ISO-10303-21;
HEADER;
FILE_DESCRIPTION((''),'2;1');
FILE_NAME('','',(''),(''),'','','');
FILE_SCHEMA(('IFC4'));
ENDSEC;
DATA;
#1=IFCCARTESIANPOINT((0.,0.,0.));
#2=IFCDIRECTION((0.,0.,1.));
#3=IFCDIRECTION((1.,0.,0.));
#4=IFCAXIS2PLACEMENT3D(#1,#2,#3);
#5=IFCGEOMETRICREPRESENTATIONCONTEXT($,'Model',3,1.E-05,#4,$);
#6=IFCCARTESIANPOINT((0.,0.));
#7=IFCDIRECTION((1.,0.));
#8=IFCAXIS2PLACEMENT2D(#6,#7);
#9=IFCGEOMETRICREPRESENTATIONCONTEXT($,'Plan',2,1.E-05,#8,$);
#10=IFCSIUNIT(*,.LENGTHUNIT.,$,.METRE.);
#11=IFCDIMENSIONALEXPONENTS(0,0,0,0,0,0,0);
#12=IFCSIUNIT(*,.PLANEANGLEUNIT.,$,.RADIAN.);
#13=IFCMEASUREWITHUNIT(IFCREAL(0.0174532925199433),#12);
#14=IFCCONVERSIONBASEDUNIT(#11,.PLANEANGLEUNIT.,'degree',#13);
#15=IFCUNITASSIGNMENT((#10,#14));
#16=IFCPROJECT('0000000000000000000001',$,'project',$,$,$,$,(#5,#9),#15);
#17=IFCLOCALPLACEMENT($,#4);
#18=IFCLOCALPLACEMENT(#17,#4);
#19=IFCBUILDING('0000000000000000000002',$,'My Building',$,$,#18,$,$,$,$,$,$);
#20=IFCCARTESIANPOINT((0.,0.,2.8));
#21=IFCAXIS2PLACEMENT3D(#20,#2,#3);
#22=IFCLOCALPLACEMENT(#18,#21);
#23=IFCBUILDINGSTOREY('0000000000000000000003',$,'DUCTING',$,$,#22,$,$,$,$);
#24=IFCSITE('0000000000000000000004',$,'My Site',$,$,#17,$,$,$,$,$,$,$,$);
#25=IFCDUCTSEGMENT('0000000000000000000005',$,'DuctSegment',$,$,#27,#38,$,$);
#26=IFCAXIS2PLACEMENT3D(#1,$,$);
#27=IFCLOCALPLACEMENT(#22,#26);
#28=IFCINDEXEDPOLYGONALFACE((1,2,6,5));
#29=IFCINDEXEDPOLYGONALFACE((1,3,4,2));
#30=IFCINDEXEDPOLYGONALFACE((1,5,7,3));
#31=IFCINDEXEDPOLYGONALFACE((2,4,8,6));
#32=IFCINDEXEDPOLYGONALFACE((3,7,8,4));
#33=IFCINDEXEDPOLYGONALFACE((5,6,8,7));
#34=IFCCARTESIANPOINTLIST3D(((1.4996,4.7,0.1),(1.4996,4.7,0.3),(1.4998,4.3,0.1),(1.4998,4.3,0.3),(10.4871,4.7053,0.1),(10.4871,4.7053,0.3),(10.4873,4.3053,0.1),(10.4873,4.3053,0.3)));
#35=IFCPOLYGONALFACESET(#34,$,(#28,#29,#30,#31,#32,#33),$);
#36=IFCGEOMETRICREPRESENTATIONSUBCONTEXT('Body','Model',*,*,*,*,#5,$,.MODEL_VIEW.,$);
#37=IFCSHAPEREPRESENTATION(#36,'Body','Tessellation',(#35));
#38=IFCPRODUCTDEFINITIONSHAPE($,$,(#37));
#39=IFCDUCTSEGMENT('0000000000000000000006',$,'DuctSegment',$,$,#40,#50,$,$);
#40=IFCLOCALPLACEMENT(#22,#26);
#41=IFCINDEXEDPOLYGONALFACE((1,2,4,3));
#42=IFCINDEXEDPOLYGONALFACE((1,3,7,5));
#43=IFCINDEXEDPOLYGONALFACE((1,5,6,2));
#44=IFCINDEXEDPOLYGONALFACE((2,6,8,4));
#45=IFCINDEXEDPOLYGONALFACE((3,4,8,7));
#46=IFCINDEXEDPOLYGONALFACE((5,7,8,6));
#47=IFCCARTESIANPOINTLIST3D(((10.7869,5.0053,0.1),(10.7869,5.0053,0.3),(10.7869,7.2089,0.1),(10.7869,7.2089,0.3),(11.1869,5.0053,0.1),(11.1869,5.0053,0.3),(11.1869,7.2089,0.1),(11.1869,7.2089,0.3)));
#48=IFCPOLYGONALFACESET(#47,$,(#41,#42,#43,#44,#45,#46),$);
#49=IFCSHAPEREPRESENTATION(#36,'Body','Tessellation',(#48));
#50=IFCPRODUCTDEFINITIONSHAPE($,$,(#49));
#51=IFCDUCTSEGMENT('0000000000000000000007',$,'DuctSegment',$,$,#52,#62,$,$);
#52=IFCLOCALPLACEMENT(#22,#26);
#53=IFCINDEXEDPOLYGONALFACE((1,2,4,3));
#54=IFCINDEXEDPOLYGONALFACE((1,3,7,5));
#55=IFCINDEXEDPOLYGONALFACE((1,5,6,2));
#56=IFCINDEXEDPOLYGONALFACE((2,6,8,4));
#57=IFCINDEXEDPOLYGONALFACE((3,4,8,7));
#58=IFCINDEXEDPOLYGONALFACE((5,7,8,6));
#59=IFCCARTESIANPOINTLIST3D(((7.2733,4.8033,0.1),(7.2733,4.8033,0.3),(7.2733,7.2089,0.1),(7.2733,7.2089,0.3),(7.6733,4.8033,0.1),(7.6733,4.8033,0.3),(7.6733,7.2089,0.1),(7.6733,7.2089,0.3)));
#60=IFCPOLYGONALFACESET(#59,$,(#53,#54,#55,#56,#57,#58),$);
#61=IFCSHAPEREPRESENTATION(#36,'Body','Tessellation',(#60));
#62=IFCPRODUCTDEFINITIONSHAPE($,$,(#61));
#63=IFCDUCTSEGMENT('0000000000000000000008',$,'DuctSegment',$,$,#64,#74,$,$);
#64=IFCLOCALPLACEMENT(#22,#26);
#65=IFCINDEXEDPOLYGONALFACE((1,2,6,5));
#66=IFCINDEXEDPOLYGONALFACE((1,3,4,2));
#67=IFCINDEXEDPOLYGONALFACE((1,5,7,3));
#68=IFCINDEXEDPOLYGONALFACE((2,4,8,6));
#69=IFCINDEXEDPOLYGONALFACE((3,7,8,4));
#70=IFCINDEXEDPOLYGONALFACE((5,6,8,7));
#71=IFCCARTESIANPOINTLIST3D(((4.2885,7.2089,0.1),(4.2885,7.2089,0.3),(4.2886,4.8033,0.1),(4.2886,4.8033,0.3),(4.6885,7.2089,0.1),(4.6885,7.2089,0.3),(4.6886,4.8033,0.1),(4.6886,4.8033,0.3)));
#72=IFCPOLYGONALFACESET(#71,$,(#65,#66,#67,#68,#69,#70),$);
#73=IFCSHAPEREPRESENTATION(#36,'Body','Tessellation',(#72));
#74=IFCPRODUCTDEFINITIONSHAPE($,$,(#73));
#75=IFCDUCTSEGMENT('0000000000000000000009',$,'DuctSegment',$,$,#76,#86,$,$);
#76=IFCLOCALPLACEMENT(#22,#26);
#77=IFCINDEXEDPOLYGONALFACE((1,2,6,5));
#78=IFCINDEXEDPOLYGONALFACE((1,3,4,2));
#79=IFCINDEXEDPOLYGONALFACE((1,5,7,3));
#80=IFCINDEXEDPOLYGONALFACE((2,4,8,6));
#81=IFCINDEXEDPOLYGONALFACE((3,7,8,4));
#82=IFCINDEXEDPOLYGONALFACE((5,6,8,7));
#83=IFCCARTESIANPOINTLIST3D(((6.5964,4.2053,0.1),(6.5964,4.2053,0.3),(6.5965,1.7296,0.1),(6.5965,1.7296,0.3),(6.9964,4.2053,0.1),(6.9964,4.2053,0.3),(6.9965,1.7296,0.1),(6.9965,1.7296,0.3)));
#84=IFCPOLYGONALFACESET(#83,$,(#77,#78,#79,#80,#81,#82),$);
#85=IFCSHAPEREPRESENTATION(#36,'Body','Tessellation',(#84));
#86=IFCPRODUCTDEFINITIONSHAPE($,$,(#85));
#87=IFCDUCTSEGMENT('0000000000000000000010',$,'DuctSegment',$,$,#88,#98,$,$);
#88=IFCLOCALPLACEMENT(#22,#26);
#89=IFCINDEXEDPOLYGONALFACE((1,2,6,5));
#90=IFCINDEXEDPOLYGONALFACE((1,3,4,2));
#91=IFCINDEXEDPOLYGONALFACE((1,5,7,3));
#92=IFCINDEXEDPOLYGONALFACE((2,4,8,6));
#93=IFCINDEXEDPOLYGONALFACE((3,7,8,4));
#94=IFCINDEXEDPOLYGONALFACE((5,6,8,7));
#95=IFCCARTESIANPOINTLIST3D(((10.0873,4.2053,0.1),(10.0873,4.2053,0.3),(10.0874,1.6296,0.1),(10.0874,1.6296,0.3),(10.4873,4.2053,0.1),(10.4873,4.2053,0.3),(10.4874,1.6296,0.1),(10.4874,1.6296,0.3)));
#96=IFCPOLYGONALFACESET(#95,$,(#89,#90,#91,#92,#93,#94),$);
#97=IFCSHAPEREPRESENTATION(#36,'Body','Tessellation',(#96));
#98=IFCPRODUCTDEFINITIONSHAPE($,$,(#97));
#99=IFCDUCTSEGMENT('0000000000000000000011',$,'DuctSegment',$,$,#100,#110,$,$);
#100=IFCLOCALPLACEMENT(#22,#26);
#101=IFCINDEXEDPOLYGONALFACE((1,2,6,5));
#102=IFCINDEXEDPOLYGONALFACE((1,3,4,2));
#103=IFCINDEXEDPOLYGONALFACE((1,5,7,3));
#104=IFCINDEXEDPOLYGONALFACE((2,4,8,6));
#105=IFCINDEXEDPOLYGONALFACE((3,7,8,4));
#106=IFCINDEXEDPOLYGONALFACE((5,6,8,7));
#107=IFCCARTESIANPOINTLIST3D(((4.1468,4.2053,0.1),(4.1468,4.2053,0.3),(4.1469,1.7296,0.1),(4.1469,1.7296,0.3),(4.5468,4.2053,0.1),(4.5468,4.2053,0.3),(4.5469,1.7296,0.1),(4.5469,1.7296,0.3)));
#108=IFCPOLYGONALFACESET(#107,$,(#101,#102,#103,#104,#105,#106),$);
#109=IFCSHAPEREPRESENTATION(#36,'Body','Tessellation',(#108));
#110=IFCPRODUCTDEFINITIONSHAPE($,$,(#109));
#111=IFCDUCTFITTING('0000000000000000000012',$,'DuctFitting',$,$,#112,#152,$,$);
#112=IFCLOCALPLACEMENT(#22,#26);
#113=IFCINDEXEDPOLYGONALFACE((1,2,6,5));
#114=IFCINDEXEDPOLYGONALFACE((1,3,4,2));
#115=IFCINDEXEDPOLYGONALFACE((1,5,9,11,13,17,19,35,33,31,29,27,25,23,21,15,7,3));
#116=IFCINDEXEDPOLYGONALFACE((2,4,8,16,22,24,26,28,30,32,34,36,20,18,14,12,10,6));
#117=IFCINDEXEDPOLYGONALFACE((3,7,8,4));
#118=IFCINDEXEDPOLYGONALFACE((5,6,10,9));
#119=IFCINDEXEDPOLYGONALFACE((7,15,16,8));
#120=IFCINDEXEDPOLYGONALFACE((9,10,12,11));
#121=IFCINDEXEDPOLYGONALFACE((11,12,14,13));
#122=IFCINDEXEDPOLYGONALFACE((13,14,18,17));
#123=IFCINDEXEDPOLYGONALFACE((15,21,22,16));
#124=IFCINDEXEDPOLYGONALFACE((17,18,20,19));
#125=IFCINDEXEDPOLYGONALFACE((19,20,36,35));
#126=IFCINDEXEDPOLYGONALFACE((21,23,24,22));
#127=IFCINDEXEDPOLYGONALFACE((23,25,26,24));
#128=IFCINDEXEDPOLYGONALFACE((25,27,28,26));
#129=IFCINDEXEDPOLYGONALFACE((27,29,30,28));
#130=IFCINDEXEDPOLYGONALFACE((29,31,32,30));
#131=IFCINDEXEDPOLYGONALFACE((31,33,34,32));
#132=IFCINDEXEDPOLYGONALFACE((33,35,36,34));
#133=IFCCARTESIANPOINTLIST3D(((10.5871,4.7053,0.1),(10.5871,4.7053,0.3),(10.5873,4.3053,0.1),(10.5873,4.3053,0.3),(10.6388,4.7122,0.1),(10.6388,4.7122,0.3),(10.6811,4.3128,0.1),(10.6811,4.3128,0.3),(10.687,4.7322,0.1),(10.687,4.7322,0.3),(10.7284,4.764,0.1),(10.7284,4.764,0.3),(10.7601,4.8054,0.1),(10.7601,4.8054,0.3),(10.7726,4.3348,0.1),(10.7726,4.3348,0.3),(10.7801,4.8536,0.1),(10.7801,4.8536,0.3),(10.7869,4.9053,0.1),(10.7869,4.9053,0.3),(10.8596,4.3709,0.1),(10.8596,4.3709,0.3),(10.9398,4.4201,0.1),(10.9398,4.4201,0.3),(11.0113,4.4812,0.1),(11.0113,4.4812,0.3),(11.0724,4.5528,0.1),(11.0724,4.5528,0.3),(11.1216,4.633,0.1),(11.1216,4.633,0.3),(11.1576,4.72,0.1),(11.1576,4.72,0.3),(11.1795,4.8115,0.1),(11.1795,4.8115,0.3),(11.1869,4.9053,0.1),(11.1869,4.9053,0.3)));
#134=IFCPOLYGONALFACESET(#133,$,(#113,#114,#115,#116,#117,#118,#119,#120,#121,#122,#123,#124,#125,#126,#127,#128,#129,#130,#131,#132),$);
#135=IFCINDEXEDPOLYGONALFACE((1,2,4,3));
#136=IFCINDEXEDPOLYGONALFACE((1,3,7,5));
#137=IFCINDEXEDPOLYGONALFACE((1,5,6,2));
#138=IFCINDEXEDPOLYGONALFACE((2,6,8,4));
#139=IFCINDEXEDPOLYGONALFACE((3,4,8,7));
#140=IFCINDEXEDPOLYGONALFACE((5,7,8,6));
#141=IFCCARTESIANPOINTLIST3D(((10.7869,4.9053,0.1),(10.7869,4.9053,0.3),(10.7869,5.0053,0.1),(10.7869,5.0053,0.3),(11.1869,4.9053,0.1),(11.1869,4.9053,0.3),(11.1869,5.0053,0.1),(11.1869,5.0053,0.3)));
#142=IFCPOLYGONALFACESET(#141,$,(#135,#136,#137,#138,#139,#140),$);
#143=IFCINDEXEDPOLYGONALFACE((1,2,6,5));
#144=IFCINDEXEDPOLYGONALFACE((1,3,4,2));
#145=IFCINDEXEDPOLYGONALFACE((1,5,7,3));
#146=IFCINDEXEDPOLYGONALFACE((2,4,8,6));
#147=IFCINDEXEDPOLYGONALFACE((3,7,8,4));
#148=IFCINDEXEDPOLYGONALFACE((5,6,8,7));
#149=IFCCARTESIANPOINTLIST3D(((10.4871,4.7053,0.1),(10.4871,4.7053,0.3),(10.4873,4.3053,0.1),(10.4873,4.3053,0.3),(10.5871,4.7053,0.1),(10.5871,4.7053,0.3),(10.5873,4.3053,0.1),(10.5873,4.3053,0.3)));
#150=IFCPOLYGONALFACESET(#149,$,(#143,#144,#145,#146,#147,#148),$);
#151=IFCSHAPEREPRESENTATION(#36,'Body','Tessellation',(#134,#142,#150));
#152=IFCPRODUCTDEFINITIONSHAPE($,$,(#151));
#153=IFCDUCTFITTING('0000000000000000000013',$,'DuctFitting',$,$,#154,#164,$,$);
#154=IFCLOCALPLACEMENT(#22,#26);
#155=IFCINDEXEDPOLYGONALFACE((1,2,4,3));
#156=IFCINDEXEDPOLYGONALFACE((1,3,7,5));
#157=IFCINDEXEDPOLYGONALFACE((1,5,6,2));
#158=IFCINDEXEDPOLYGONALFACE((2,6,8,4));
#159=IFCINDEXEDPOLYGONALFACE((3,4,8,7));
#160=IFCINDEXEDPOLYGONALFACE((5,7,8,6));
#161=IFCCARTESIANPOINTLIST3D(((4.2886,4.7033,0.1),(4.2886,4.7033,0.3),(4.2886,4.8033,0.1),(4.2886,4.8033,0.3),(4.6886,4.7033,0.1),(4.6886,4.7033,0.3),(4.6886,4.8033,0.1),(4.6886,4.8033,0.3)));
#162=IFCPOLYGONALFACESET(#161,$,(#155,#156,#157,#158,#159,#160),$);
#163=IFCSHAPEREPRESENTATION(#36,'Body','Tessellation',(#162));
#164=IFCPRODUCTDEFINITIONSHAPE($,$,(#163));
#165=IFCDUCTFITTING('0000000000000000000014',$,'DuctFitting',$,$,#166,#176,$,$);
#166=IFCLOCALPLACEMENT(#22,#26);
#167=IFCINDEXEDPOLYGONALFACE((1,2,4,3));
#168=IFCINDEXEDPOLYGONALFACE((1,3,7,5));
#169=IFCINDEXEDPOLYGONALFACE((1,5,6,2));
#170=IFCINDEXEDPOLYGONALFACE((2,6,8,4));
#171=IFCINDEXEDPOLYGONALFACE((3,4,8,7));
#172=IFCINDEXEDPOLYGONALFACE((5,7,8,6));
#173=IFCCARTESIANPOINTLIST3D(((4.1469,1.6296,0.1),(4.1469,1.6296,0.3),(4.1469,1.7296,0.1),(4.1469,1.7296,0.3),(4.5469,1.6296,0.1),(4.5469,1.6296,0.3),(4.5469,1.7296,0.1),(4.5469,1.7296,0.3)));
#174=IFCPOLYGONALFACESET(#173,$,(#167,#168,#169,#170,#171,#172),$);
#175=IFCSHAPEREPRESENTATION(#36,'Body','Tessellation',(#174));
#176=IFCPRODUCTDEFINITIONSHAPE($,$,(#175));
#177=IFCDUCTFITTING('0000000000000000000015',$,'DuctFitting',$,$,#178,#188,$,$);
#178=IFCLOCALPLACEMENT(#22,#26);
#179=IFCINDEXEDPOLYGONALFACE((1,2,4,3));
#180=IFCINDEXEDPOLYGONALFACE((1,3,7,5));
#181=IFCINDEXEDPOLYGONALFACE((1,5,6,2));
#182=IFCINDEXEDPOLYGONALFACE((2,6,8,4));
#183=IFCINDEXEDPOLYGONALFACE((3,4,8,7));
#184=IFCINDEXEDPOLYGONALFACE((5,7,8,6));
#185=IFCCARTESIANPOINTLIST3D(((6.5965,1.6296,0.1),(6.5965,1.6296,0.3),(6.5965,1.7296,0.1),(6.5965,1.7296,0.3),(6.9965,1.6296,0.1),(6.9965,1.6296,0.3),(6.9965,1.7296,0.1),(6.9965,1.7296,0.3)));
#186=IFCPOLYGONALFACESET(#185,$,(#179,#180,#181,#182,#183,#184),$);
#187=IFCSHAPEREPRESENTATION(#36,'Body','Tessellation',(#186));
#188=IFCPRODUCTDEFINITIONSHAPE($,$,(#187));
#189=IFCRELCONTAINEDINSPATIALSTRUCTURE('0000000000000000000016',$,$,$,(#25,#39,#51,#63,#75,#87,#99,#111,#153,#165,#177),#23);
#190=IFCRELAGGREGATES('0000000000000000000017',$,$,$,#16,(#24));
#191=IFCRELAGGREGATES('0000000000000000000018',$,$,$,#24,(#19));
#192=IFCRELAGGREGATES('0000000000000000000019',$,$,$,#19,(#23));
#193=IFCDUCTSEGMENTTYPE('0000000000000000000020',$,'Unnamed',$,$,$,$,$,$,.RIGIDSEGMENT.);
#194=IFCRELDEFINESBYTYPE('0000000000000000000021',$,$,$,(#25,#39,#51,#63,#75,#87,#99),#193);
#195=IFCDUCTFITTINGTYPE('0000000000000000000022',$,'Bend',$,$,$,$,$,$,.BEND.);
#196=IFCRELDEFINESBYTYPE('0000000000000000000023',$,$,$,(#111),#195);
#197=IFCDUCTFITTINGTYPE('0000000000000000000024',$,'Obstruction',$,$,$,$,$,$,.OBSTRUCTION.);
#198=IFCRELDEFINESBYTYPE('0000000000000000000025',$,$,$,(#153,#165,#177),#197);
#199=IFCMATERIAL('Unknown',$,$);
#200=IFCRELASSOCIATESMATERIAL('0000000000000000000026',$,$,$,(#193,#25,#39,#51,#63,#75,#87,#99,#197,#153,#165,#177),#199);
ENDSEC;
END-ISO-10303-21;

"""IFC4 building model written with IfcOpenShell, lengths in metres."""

from ifc_helpers import new_model, entity, si_unit, converted_unit, frame, origin_with_axes, origin_2d_with_axis, place, context, subcontext, project, spatial, line, arc, indexed_curve, rectangle, outline, extrude, source, transform, mapped, material, material_profile, profile_set, profile_usage, type_object, type_shapes, element, save


model = new_model("IFC4")

# Units and contexts
model_context = context("Model", 3, precision=1e-05, world=origin_with_axes())
plan_context = context("Plan", 2, precision=1e-05, world=origin_2d_with_axis())
body_context = subcontext(model_context, "Body", "Model", "MODEL_VIEW")
ifc_project = project(units=[si_unit("LENGTHUNIT", "METRE"), converted_unit("PLANEANGLEUNIT", "degree", entity("IfcReal", 0.0174532925199433), si_unit("PLANEANGLEUNIT", "RADIAN"), dimensions=[0, 0, 0, 0, 0, 0, 0])], contexts=[model_context, plan_context])

# Site, building, storey
site_placement = place(None, origin_with_axes())
site = spatial("IfcSite", under=ifc_project, at=site_placement, Name="My Site")
building_placement = place(site_placement, origin_with_axes())
building = spatial("IfcBuilding", under=site, at=building_placement, Name="My Building")
storey_placement = place(building_placement, frame((0.0, 0.0, 2.8), z_axis=(0.0, 0.0, 1.0), x_axis=(1.0, 0.0, 0.0)))
storey = spatial("IfcBuildingStorey", under=building, at=storey_placement, Name="DUCTING")

# Duct segments
ifc_material = material(Name="Unknown")
ifc_material_profile_1 = material_profile(ifc_material, rectangle(XDim=0.4, YDim=0.2))
ifc_profile_set_1 = profile_set([ifc_material_profile_1])
ifc_profile_usage_1 = profile_usage(ifc_profile_set_1, cardinal=5)
duct_segment_type = type_object("IfcDuctSegmentType", Name="Unnamed", PredefinedType="RIGIDSEGMENT", material=ifc_profile_set_1)
duct_segment_1_placement = place(storey_placement, frame((1.4997, 4.5, 0.2), z_axis=(1.0, 0.000585, 0.0), x_axis=(-0.000585, 1.0, 0.0)))
element("IfcDuctSegment", 1, at=duct_segment_1_placement, inside=storey, type_object=duct_segment_type, material=ifc_profile_usage_1, Name="DuctSegment", context=body_context, shape_type="SweptSolid", body=[
    extrude(rectangle(XDim=0.4, YDim=0.2), origin_with_axes(), (0.0, 0.0, 1.0), 8.9875),
])
ifc_profile_usage_2 = profile_usage(ifc_profile_set_1, cardinal=5)
duct_segment_2_placement = place(storey_placement, frame((10.9869, 5.0053, 0.2), z_axis=(0.0, 1.0, 0.0), x_axis=(-1.0, 0.0, 0.0)))
element("IfcDuctSegment", 2, at=duct_segment_2_placement, inside=storey, type_object=duct_segment_type, material=ifc_profile_usage_2, Name="DuctSegment", context=body_context, shape_type="SweptSolid", body=[
    extrude(rectangle(XDim=0.4, YDim=0.2), origin_with_axes(), (0.0, 0.0, 1.0), 2.2036),
])
ifc_profile_usage_3 = profile_usage(ifc_profile_set_1, cardinal=5)
duct_segment_3_placement = place(storey_placement, frame((7.4733, 4.8033, 0.2), z_axis=(-0.000031, 1.0, 0.0), x_axis=(-1.0, -0.000031, 0.0)))
element("IfcDuctSegment", 3, at=duct_segment_3_placement, inside=storey, type_object=duct_segment_type, material=ifc_profile_usage_3, Name="DuctSegment", context=body_context, shape_type="SweptSolid", body=[
    extrude(rectangle(XDim=0.4, YDim=0.2), origin_with_axes(), (0.0, 0.0, 1.0), 2.4056),
])
ifc_profile_usage_4 = profile_usage(ifc_profile_set_1, cardinal=5)
duct_segment_4_placement = place(storey_placement, frame((4.4886, 4.8033, 0.2), z_axis=(-0.000031, 1.0, 0.0), x_axis=(-1.0, -0.000031, 0.0)))
element("IfcDuctSegment", 4, at=duct_segment_4_placement, inside=storey, type_object=duct_segment_type, material=ifc_profile_usage_4, Name="DuctSegment", context=body_context, shape_type="SweptSolid", body=[
    extrude(rectangle(XDim=0.4, YDim=0.2), origin_with_axes(), (0.0, 0.0, 1.0), 2.4056),
])
ifc_profile_usage_5 = profile_usage(ifc_profile_set_1, cardinal=5)
duct_segment_5_placement = place(storey_placement, frame((6.7965, 1.7296, 0.2), z_axis=(-0.000031, 1.0, 0.0), x_axis=(-1.0, -0.000031, 0.0)))
element("IfcDuctSegment", 5, at=duct_segment_5_placement, inside=storey, type_object=duct_segment_type, material=ifc_profile_usage_5, Name="DuctSegment", context=body_context, shape_type="SweptSolid", body=[
    extrude(rectangle(XDim=0.4, YDim=0.2), origin_with_axes(), (0.0, 0.0, 1.0), 2.4756),
])
ifc_profile_usage_6 = profile_usage(ifc_profile_set_1, cardinal=5)
duct_segment_6_placement = place(storey_placement, frame((10.2874, 1.6296, 0.2), z_axis=(-0.000031, 1.0, 0.0), x_axis=(-1.0, -0.000031, 0.0)))
element("IfcDuctSegment", 6, at=duct_segment_6_placement, inside=storey, type_object=duct_segment_type, material=ifc_profile_usage_6, Name="DuctSegment", context=body_context, shape_type="SweptSolid", body=[
    extrude(rectangle(XDim=0.4, YDim=0.2), origin_with_axes(), (0.0, 0.0, 1.0), 2.5756),
])
ifc_profile_usage_7 = profile_usage(ifc_profile_set_1, cardinal=5)
duct_segment_7_placement = place(storey_placement, frame((4.3469, 1.7296, 0.2), z_axis=(-0.000031, 1.0, 0.0), x_axis=(-1.0, -0.000031, 0.0)))
element("IfcDuctSegment", 7, at=duct_segment_7_placement, inside=storey, type_object=duct_segment_type, material=ifc_profile_usage_7, Name="DuctSegment", context=body_context, shape_type="SweptSolid", body=[
    extrude(rectangle(XDim=0.4, YDim=0.2), origin_with_axes(), (0.0, 0.0, 1.0), 2.4756),
])

# Duct fittings
duct_fitting_type_1 = type_object("IfcDuctFittingType", Name="Bend", PredefinedType="BEND")
shared_shape = source(origin_with_axes(), body_context, "Body", "SweptSolid", [
    extrude(outline(indexed_curve([(0.2, 0.0), (0.2585, -0.1414), (0.3999, -0.2), (0.3996, -0.6), (-0.0244, -0.4241), (-0.2, 0.0)], segments=[arc(1, 2, 3), line(3, 4), arc(4, 5, 6), line(6, 1)])), frame((0.0, -0.1, -0.1), z_axis=(0.0, -1.0, 0.0), x_axis=(1.0, 0.0, 0.0)), (0.0, 0.0, -1.0), 0.2),
    extrude(rectangle(XDim=0.4, YDim=0.2), origin_with_axes(), (0.0, 0.0, -1.0), 0.1),
    extrude(rectangle(XDim=0.4, YDim=0.2), frame((0.3997, 0.0, -0.5), z_axis=(1.0, 0.0, -0.000684), x_axis=(0.000684, 0.0, 1.0)), (0.0, 0.0, 1.0), 0.1),
])
type_shapes(duct_fitting_type_1, [shared_shape])
duct_fitting_1_placement = place(storey_placement, frame((10.9869, 5.0053, 0.2), z_axis=(0.0, 1.0, 0.0), x_axis=(-1.0, 0.0, 0.0)))
element("IfcDuctFitting", 8, at=duct_fitting_1_placement, inside=storey, type_object=duct_fitting_type_1, Name="DuctFitting", context=body_context, shape_type="MappedRepresentation", body=[
    mapped(shared_shape, transform((0.0, 0.0, 0.0), x_axis=(1.0, 0.0, 0.0), y_axis=(0.0, 1.0, 0.0), z_axis=(0.0, 0.0, 1.0), scale=1.0)),
])
ifc_material_profile_2 = material_profile(ifc_material, rectangle(XDim=0.4, YDim=0.2))
ifc_profile_set_2 = profile_set([ifc_material_profile_2])
ifc_profile_usage_8 = profile_usage(ifc_profile_set_2, cardinal=5)
duct_fitting_type_2 = type_object("IfcDuctFittingType", Name="Obstruction", PredefinedType="OBSTRUCTION", material=ifc_profile_set_2)
duct_fitting_2_placement = place(storey_placement, frame((4.4886, 4.7033, 0.2), z_axis=(-0.000031, 1.0, 0.0), x_axis=(-1.0, -0.000031, 0.0)))
element("IfcDuctFitting", 9, at=duct_fitting_2_placement, inside=storey, type_object=duct_fitting_type_2, material=ifc_profile_usage_8, Name="DuctFitting", context=body_context, shape_type="SweptSolid", body=[
    extrude(rectangle(XDim=0.4, YDim=0.2), origin_with_axes(), (0.0, 0.0, 1.0), 0.1),
])
ifc_profile_usage_9 = profile_usage(ifc_profile_set_2, cardinal=5)
duct_fitting_3_placement = place(storey_placement, frame((4.3469, 1.6296, 0.2), z_axis=(-0.000031, 1.0, 0.0), x_axis=(-1.0, -0.000031, 0.0)))
element("IfcDuctFitting", 10, at=duct_fitting_3_placement, inside=storey, type_object=duct_fitting_type_2, material=ifc_profile_usage_9, Name="DuctFitting", context=body_context, shape_type="SweptSolid", body=[
    extrude(rectangle(XDim=0.4, YDim=0.2), origin_with_axes(), (0.0, 0.0, 1.0), 0.1),
])
ifc_profile_usage_10 = profile_usage(ifc_profile_set_2, cardinal=5)
duct_fitting_4_placement = place(storey_placement, frame((6.7965, 1.6296, 0.2), z_axis=(-0.000031, 1.0, 0.0), x_axis=(-1.0, -0.000031, 0.0)))
element("IfcDuctFitting", 11, at=duct_fitting_4_placement, inside=storey, type_object=duct_fitting_type_2, material=ifc_profile_usage_10, Name="DuctFitting", context=body_context, shape_type="SweptSolid", body=[
    extrude(rectangle(XDim=0.4, YDim=0.2), origin_with_axes(), (0.0, 0.0, 1.0), 0.1),
])

save(model, "model.ifc")
